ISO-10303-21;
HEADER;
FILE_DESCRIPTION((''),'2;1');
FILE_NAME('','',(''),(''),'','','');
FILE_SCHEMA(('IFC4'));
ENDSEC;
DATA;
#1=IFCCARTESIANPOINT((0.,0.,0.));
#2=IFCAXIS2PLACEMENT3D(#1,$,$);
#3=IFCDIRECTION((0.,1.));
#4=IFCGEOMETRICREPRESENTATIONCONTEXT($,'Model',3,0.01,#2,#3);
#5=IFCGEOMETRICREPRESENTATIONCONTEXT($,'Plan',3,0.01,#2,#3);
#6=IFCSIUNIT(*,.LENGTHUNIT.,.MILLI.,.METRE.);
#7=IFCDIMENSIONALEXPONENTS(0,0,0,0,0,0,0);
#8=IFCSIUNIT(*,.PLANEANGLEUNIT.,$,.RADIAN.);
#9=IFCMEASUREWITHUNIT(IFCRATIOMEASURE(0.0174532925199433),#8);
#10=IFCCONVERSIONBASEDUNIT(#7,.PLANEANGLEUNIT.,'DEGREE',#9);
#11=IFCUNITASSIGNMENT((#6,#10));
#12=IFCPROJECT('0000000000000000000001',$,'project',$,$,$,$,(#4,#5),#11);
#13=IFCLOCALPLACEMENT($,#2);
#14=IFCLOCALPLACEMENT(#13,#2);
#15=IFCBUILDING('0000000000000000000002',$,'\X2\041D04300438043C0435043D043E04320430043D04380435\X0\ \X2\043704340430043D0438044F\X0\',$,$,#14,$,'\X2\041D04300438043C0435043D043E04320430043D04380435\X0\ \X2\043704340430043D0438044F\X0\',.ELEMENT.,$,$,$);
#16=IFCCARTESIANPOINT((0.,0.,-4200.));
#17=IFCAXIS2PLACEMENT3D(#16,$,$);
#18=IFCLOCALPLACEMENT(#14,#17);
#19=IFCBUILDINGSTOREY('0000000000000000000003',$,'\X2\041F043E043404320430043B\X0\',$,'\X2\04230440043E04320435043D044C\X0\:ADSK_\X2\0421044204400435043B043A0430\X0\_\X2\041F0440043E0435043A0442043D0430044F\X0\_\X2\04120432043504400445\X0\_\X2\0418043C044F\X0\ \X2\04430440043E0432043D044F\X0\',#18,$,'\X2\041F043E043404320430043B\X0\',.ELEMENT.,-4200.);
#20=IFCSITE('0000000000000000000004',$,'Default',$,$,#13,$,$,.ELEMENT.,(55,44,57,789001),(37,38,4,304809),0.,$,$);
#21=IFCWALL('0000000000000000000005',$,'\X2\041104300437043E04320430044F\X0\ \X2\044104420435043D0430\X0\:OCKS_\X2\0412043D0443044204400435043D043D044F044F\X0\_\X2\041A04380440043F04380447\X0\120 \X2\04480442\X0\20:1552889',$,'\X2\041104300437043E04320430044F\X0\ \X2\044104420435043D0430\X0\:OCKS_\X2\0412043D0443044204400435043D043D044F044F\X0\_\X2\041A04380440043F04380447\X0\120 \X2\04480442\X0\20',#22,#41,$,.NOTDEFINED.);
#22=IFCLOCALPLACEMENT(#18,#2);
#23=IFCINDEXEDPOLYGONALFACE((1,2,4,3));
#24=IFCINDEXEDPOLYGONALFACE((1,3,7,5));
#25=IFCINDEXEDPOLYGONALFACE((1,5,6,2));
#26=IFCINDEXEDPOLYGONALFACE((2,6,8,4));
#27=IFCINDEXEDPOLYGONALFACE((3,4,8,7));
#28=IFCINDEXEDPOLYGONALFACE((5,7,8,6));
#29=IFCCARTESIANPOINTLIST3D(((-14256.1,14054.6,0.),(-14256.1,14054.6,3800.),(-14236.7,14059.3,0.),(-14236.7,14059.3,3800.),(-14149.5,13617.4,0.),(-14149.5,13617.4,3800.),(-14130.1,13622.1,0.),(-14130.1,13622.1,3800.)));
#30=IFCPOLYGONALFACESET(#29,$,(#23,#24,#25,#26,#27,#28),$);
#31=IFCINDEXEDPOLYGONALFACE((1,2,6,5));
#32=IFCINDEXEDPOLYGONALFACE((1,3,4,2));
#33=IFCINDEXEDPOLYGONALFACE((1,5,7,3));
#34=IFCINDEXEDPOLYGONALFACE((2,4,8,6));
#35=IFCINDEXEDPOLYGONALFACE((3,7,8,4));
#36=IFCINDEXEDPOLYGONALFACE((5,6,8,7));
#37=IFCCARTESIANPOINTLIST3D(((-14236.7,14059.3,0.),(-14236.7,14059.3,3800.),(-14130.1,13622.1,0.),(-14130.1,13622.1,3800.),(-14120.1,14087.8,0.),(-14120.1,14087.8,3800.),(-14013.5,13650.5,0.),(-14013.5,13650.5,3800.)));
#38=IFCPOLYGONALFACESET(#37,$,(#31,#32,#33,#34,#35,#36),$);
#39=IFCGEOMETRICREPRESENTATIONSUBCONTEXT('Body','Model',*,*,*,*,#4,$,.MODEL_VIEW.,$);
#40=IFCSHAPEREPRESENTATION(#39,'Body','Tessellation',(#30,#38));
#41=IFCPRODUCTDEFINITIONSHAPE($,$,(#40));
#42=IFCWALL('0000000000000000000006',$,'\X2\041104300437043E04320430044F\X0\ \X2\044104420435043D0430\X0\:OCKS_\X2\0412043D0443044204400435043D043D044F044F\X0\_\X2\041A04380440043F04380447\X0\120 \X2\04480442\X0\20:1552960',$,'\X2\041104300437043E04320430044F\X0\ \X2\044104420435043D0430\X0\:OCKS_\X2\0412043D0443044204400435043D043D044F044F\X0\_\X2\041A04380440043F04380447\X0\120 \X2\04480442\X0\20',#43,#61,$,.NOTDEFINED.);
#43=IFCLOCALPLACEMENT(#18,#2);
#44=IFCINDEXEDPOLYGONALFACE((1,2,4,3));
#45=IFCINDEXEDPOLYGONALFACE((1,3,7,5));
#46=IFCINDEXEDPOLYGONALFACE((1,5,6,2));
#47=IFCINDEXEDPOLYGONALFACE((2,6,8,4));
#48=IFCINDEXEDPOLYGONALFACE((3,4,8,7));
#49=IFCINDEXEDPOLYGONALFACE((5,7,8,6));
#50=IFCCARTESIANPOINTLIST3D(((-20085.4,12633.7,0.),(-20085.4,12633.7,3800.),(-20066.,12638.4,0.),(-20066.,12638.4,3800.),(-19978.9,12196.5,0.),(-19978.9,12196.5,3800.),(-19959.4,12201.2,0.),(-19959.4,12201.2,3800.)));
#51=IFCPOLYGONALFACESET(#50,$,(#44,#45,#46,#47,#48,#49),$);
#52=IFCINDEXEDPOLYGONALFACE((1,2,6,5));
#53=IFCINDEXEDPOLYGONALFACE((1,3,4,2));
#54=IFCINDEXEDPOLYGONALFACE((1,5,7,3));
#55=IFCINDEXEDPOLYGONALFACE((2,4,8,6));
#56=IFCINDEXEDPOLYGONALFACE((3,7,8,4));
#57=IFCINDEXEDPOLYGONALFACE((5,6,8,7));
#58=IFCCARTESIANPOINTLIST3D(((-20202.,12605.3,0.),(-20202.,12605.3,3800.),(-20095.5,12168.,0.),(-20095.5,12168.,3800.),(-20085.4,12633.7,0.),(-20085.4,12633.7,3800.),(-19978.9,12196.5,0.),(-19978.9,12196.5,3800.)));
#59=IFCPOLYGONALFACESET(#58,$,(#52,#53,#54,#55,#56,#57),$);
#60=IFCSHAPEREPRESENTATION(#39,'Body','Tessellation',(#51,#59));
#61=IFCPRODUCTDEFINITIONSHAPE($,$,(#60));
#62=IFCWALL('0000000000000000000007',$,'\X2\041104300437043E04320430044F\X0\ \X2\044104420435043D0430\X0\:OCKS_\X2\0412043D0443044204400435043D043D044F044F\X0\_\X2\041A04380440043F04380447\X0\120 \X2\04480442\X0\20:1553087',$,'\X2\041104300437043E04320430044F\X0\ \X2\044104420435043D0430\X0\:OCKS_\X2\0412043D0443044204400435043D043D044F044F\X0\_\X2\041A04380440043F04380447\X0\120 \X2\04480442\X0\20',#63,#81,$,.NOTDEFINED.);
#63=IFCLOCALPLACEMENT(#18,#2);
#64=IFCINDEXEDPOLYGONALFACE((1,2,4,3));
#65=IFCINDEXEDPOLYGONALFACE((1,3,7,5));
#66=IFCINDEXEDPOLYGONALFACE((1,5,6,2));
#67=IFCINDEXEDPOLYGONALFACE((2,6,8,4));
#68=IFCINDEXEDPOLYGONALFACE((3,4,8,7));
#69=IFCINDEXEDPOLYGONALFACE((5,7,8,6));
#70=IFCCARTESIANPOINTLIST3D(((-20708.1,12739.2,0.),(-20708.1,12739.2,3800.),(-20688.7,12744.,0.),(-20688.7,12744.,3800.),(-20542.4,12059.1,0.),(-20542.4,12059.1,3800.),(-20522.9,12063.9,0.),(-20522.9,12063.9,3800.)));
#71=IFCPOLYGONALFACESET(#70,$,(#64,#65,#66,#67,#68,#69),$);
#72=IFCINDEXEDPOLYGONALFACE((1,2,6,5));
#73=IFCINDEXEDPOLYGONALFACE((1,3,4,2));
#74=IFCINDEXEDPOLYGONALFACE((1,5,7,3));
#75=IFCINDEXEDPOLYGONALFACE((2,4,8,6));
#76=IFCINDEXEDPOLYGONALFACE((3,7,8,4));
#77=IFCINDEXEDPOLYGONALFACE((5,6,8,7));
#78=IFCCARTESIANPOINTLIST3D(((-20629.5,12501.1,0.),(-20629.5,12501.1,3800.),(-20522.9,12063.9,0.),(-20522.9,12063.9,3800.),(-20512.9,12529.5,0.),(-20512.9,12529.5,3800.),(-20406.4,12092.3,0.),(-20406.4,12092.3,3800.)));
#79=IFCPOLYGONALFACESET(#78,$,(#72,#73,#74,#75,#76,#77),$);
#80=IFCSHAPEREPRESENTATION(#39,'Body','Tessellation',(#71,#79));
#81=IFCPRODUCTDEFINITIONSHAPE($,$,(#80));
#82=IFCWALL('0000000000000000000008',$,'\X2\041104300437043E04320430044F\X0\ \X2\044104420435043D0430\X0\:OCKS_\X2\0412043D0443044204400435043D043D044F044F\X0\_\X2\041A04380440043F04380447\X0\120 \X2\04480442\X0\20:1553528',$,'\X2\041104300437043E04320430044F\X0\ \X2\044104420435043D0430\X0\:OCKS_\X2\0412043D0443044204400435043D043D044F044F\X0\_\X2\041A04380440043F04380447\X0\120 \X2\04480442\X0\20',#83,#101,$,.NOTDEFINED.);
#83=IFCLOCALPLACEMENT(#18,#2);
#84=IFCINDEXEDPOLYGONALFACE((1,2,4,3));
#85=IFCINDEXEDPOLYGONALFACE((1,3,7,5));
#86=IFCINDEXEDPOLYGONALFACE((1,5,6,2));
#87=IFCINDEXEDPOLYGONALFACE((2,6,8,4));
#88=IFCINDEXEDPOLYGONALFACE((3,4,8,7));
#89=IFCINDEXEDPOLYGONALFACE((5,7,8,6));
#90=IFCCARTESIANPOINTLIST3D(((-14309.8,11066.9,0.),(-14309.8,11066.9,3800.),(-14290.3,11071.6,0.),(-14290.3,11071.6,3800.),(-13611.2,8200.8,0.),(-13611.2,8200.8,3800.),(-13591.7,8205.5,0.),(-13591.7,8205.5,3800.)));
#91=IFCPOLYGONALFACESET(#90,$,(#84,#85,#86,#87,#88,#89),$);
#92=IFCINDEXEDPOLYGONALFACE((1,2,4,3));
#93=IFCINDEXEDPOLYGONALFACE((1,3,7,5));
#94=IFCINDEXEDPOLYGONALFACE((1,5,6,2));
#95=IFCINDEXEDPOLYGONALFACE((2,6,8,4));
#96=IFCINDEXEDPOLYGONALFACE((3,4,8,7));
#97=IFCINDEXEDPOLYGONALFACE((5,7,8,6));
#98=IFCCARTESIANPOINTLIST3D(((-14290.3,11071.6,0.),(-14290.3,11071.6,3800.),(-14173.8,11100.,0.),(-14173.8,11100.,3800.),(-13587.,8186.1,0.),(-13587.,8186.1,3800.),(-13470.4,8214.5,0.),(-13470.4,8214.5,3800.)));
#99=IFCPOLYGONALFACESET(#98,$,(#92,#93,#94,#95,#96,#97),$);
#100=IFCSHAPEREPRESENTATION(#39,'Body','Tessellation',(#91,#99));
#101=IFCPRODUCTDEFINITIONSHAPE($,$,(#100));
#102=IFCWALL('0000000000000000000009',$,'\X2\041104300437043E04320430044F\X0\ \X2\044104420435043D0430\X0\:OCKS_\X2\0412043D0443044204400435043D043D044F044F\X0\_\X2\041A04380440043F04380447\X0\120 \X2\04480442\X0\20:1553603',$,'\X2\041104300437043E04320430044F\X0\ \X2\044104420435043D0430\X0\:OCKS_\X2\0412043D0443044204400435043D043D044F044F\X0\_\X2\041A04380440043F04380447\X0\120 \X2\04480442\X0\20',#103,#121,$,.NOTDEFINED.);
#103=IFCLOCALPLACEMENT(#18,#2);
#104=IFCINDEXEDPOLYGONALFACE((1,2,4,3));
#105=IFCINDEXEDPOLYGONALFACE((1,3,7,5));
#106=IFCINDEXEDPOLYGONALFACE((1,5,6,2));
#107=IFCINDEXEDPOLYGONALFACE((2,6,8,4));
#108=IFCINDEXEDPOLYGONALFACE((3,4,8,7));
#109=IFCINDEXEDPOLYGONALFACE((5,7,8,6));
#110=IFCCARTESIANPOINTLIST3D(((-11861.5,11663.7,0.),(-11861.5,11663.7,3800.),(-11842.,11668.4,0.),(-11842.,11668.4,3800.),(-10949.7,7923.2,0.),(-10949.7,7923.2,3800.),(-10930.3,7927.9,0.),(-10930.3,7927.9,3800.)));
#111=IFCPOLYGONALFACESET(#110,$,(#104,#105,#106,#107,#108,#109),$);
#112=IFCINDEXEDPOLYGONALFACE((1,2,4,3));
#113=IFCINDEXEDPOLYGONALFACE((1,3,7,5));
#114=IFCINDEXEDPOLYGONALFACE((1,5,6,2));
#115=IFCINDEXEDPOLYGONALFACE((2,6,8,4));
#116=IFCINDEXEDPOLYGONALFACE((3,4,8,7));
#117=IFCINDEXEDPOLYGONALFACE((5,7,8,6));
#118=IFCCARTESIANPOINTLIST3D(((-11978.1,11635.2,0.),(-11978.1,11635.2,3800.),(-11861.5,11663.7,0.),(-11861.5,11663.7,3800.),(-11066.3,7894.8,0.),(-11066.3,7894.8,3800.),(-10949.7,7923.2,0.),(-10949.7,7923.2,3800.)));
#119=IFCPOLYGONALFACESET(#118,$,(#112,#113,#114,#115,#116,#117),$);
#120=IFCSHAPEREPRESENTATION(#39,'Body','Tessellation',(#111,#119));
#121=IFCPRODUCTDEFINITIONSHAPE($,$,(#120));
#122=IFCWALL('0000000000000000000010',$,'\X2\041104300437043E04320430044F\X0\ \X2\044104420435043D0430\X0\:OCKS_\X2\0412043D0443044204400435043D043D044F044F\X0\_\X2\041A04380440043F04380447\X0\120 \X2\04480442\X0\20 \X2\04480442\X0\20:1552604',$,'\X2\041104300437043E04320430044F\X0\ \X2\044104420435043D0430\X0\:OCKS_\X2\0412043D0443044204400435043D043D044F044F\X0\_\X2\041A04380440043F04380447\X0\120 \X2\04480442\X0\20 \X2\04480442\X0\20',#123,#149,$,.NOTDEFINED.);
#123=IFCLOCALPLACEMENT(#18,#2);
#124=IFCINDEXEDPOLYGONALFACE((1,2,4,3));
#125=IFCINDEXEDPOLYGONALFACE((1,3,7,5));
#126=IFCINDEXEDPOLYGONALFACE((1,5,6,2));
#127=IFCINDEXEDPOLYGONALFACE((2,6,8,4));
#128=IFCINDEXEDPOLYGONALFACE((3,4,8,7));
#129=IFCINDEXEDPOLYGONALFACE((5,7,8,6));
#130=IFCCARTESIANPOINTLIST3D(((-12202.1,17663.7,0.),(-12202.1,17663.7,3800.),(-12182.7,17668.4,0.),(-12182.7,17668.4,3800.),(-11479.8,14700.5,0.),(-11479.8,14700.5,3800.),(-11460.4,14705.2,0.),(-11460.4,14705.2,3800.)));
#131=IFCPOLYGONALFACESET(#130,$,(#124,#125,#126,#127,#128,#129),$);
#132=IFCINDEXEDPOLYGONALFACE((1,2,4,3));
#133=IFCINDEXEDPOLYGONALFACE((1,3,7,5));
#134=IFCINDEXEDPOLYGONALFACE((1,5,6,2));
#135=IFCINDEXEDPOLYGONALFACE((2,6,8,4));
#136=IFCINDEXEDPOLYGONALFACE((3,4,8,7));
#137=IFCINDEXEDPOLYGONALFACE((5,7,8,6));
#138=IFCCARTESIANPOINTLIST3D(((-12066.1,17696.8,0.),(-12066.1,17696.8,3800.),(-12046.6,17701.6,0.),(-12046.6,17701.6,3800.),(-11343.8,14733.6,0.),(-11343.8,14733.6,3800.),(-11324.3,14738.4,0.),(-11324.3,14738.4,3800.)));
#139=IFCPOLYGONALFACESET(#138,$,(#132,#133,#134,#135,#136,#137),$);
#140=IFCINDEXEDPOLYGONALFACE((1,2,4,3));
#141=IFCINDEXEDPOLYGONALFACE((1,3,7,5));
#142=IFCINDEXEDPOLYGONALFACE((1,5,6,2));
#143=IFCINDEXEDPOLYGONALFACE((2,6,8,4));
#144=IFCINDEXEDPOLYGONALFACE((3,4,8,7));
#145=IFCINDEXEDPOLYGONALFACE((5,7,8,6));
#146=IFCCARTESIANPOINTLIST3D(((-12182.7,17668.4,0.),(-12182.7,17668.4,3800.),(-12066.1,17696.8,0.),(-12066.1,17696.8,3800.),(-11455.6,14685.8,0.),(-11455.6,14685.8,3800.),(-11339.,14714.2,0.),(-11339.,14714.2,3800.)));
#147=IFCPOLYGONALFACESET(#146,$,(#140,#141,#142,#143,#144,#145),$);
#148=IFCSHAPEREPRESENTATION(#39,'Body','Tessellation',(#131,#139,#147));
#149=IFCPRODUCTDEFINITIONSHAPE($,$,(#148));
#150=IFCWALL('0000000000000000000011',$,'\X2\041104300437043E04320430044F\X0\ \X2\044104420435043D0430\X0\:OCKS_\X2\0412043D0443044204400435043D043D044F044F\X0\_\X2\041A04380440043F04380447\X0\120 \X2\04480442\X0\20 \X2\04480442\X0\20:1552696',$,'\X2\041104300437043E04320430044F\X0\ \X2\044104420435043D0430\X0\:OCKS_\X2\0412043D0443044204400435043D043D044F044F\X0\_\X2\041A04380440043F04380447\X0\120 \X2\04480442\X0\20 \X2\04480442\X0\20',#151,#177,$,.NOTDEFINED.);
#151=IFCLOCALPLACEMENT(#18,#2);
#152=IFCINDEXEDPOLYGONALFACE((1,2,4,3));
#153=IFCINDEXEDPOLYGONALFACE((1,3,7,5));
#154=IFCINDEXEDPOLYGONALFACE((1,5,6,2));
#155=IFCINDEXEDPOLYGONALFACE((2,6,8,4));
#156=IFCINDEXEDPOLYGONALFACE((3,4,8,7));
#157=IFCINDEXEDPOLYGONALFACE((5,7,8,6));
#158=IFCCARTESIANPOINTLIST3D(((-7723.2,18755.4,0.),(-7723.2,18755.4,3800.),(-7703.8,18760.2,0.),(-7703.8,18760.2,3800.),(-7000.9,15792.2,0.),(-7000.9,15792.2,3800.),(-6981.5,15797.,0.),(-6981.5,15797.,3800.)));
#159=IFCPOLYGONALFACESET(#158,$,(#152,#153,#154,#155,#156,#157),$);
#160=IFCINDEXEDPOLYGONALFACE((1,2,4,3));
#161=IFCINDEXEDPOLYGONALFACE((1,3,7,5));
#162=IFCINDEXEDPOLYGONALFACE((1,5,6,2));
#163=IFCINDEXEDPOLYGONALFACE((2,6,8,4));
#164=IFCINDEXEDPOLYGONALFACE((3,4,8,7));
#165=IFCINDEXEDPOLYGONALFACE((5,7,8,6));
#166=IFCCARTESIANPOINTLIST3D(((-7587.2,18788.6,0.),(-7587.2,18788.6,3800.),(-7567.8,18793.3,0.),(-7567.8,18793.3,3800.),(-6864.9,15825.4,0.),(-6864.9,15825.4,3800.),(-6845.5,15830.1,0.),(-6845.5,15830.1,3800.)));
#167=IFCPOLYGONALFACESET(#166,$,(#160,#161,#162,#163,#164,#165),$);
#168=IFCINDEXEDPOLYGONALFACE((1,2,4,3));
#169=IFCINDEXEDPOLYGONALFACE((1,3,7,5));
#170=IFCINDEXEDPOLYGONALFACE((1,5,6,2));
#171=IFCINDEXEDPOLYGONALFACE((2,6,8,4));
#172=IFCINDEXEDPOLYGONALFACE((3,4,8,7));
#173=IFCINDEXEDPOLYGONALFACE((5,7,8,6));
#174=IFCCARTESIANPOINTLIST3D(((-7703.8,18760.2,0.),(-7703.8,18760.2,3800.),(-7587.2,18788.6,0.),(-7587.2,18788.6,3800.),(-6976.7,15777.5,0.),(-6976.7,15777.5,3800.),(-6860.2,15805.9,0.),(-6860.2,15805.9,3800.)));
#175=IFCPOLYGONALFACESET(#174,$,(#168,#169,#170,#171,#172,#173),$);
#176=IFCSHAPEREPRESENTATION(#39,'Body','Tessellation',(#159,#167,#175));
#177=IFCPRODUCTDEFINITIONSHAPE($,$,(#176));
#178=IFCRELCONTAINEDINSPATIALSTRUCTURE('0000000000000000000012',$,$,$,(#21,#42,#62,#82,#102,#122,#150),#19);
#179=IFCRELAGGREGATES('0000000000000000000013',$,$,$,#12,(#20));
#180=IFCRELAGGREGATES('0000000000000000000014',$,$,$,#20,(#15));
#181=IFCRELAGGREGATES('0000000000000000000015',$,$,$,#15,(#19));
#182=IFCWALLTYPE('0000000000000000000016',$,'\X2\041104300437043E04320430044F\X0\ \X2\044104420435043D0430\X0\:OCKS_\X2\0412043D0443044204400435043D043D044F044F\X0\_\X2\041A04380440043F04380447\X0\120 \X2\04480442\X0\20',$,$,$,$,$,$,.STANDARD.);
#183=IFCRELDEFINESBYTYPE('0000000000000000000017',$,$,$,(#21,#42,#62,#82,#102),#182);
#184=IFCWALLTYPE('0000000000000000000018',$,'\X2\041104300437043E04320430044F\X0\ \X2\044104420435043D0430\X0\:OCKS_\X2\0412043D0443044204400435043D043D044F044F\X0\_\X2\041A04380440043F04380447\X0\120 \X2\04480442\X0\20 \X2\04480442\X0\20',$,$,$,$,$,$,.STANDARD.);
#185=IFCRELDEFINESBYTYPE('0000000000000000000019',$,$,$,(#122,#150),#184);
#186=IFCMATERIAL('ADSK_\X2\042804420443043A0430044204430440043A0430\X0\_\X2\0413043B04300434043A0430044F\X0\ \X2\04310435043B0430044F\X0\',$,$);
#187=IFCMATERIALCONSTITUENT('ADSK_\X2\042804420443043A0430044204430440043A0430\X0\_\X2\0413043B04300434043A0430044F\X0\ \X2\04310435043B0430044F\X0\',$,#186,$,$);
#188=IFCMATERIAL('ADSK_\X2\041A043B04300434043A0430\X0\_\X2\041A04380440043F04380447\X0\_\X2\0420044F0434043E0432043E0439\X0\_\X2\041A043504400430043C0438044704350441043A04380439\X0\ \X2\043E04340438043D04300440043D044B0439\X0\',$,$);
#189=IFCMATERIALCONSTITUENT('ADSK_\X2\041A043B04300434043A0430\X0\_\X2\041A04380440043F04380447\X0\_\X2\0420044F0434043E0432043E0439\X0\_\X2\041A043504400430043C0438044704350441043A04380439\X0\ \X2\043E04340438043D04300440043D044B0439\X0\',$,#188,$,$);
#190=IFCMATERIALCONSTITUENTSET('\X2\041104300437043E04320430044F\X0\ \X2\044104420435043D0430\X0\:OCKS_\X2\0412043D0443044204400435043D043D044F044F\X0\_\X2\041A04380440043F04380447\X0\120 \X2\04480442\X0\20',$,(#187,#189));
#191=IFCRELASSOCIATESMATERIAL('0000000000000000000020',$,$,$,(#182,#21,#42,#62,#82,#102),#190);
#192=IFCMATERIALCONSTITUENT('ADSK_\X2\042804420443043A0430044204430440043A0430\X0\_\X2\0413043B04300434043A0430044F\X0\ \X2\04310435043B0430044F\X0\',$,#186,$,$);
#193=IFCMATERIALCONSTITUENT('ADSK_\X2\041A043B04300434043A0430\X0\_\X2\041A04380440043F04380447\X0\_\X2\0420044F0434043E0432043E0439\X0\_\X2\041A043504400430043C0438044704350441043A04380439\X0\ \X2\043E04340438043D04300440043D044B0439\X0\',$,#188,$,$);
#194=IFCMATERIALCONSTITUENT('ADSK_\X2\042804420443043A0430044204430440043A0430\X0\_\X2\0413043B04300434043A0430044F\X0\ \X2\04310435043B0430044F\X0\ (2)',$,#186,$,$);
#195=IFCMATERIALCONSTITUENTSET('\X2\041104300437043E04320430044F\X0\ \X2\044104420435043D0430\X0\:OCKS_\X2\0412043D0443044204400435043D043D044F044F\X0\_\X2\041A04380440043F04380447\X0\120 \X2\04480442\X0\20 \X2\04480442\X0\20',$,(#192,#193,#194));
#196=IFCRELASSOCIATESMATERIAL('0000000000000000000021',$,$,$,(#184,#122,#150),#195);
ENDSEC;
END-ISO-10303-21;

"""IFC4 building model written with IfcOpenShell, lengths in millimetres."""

from ifc_helpers import new_model, entity, si_unit, converted_unit, direction, frame, origin, place, context, subcontext, project, spatial, indexed_curve, outline, extrude, material, constituent, constituent_set, type_object, element, save


model = new_model("IFC4")

# Units and contexts
model_context = context("Model", 3, precision=0.01, world=origin(), true_north=direction((0.0, 1.0)))
plan_context = context("Plan", 3, precision=0.01, world=origin(), true_north=direction((0.0, 1.0)))
body_context = subcontext(model_context, "Body", "Model", "MODEL_VIEW")
ifc_project = project(units=[si_unit("LENGTHUNIT", "METRE", prefix="MILLI"), converted_unit("PLANEANGLEUNIT", "DEGREE", entity("IfcRatioMeasure", 0.0174532925199433), si_unit("PLANEANGLEUNIT", "RADIAN"), dimensions=[0, 0, 0, 0, 0, 0, 0])], contexts=[model_context, plan_context])

# Site, building, storey
site_placement = place(None, frame((0.0, 0.0, 0.0)))
site = spatial("IfcSite", under=ifc_project, at=site_placement, Name="Default", CompositionType="ELEMENT", RefLatitude=(55, 44, 57, 789001), RefLongitude=(37, 38, 4, 304809), RefElevation=0.0)
building_placement = place(site_placement, origin())
building = spatial("IfcBuilding", under=site, at=building_placement, Name="Наименование здания", LongName="Наименование здания", CompositionType="ELEMENT")
storey_placement = place(building_placement, frame((0.0, 0.0, -4200.0)))
storey = spatial("IfcBuildingStorey", under=building, at=storey_placement, Name="Подвал", ObjectType="Уровень:ADSK_Стрелка_Проектная_Вверх_Имя уровня", LongName="Подвал", CompositionType="ELEMENT", Elevation=-4200.0)

# Walls
ifc_material_1 = material(Name="ADSK_Штукатурка_Гладкая белая")
ifc_constituent_1 = constituent(ifc_material_1, Name="ADSK_Штукатурка_Гладкая белая")
ifc_material_2 = material(Name="ADSK_Кладка_Кирпич_Рядовой_Керамический одинарный")
ifc_constituent_2 = constituent(ifc_material_2, Name="ADSK_Кладка_Кирпич_Рядовой_Керамический одинарный")
ifc_constituent_set_1 = constituent_set(constituents=[ifc_constituent_1, ifc_constituent_2], Name="Базовая стена:OCKS_Внутренняя_Кирпич120 шт20")
wall_type_1 = type_object("IfcWallType", Name="Базовая стена:OCKS_Внутренняя_Кирпич120 шт20", PredefinedType="STANDARD", material=ifc_constituent_set_1)
wall_1_placement = place(storey_placement, frame((-14081.5, 13634.0, 0.0), z_axis=(0.0, 0.0, 1.0), x_axis=(-0.236821, 0.971553, 0.0)))
element("IfcWall", 1, at=wall_1_placement, inside=storey, type_object=wall_type_1, material=ifc_constituent_set_1, Name="Базовая стена:OCKS_Внутренняя_Кирпич120 шт20:1552889", ObjectType="Базовая стена:OCKS_Внутренняя_Кирпич120 шт20", PredefinedType="NOTDEFINED", context=body_context, shape_type="SweptSolid", body=[
    extrude(outline(indexed_curve([(-10.0, -225.0), (10.0, -225.0), (10.0, 225.0), (-10.0, 225.0), (-10.0, -225.0)], self_intersect=False)), frame((225.0, 60.0, 0.0), z_axis=(0.0, 0.0, 1.0), x_axis=(0.0, -1.0, 0.0)), (0.0, 0.0, 1.0), 3800.0),
    extrude(outline(indexed_curve([(-60.0, -225.0), (60.0, -225.0), (60.0, 225.0), (-60.0, 225.0), (-60.0, -225.0)], self_intersect=False)), frame((225.0, -10.0, 0.0), z_axis=(0.0, 0.0, 1.0), x_axis=(0.0, 1.0, 0.0)), (0.0, 0.0, 1.0), 3800.0),
])
wall_2_placement = place(storey_placement, frame((-20027.4, 12184.6, 0.0), z_axis=(0.0, 0.0, 1.0), x_axis=(-0.23682, 0.971553, 0.0)))
element("IfcWall", 2, at=wall_2_placement, inside=storey, type_object=wall_type_1, material=ifc_constituent_set_1, Name="Базовая стена:OCKS_Внутренняя_Кирпич120 шт20:1552960", ObjectType="Базовая стена:OCKS_Внутренняя_Кирпич120 шт20", PredefinedType="NOTDEFINED", context=body_context, shape_type="SweptSolid", body=[
    extrude(outline(indexed_curve([(-10.0, -225.0), (10.0, -225.0), (10.0, 225.0), (-10.0, 225.0), (-10.0, -225.0)], self_intersect=False)), frame((225.0, -60.0, 0.0), z_axis=(0.0, 0.0, 1.0), x_axis=(0.0, 1.0, 0.0)), (0.0, 0.0, 1.0), 3800.0),
    extrude(outline(indexed_curve([(-60.0, -225.0), (60.0, -225.0), (60.0, 225.0), (-60.0, 225.0), (-60.0, -225.0)], self_intersect=False)), frame((225.0, 10.0, 0.0), z_axis=(0.0, 0.0, 1.0), x_axis=(0.0, -1.0, 0.0)), (0.0, 0.0, 1.0), 3800.0),
])
wall_3_placement = place(storey_placement, frame((-20580.9, 12512.9, 0.0), z_axis=(0.0, 0.0, 1.0), x_axis=(0.236822, -0.971553, 0.0)))
element("IfcWall", 3, at=wall_3_placement, inside=storey, type_object=wall_type_1, material=ifc_constituent_set_1, Name="Базовая стена:OCKS_Внутренняя_Кирпич120 шт20:1553087", ObjectType="Базовая стена:OCKS_Внутренняя_Кирпич120 шт20", PredefinedType="NOTDEFINED", context=body_context, shape_type="SweptSolid", body=[
    extrude(outline(indexed_curve([(-10.0, -350.0), (10.0, -350.0), (10.0, 350.0), (-10.0, 350.0), (-10.0, -350.0)], self_intersect=False)), frame((100.0, -60.0, 0.0), z_axis=(0.0, 0.0, 1.0), x_axis=(0.0, 1.0, 0.0)), (0.0, 0.0, 1.0), 3800.0),
    extrude(outline(indexed_curve([(-60.0, -225.0), (60.0, -225.0), (60.0, 225.0), (-60.0, 225.0), (-60.0, -225.0)], self_intersect=False)), frame((225.0, 10.0, 0.0), z_axis=(0.0, 0.0, 1.0), x_axis=(-0.000002, -1.0, 0.0)), (0.0, 0.0, 1.0), 3800.0),
])
wall_4_placement = place(storey_placement, frame((-13543.2, 8217.4, 0.0), z_axis=(0.0, 0.0, 1.0), x_axis=(-0.236815, 0.971555, 0.0)))
element("IfcWall", 4, at=wall_4_placement, inside=storey, type_object=wall_type_1, material=ifc_constituent_set_1, Name="Базовая стена:OCKS_Внутренняя_Кирпич120 шт20:1553528", ObjectType="Базовая стена:OCKS_Внутренняя_Кирпич120 шт20", PredefinedType="NOTDEFINED", context=body_context, shape_type="SweptSolid", body=[
    extrude(outline(indexed_curve([(-10.0, -1475.0), (10.0, -1475.0), (10.0, 1475.0), (-10.0, 1475.0), (-10.0, -1475.0)], self_intersect=False)), frame((1475.0, 60.0, 0.0), z_axis=(0.0, 0.0, 1.0), x_axis=(0.000006, -1.0, 0.0)), (0.0, 0.0, 1.0), 3800.0),
    extrude(outline(indexed_curve([(-60.0, -1485.0), (60.0, -1485.0), (60.0, 1485.0), (-60.0, 1485.0), (-60.0, -1485.0)], self_intersect=False)), frame((1465.0, -10.0, 0.0), z_axis=(0.0, 0.0, 1.0), x_axis=(-0.000006, 1.0, 0.0)), (0.0, 0.0, 1.0), 3800.0),
])
wall_5_placement = place(storey_placement, frame((-11910.1, 11651.8, 0.0), z_axis=(0.0, 0.0, 1.0), x_axis=(0.236821, -0.971553, 0.0)))
element("IfcWall", 5, at=wall_5_placement, inside=storey, type_object=wall_type_1, material=ifc_constituent_set_1, Name="Базовая стена:OCKS_Внутренняя_Кирпич120 шт20:1553603", ObjectType="Базовая стена:OCKS_Внутренняя_Кирпич120 шт20", PredefinedType="NOTDEFINED", context=body_context, shape_type="SweptSolid", body=[
    extrude(outline(indexed_curve([(-10.0, -1925.0), (10.0, -1925.0), (10.0, 1925.0), (-10.0, 1925.0), (-10.0, -1925.0)], self_intersect=False)), frame((1925.0, 60.0, 0.0), z_axis=(0.0, 0.0, 1.0), x_axis=(0.0, -1.0, 0.0)), (0.0, 0.0, 1.0), 3800.0),
    extrude(outline(indexed_curve([(-60.0, -1925.0), (60.0, -1925.0), (60.0, 1925.0), (-60.0, 1925.0), (-60.0, -1925.0)], self_intersect=False)), frame((1925.0, -10.0, 0.0), z_axis=(0.0, 0.0, 1.0), x_axis=(0.0, 1.0, 0.0)), (0.0, 0.0, 1.0), 3800.0),
])
ifc_constituent_3 = constituent(ifc_material_1, Name="ADSK_Штукатурка_Гладкая белая")
ifc_constituent_4 = constituent(ifc_material_2, Name="ADSK_Кладка_Кирпич_Рядовой_Керамический одинарный")
ifc_constituent_5 = constituent(ifc_material_1, Name="ADSK_Штукатурка_Гладкая белая (2)")
ifc_constituent_set_2 = constituent_set(constituents=[ifc_constituent_3, ifc_constituent_4, ifc_constituent_5], Name="Базовая стена:OCKS_Внутренняя_Кирпич120 шт20 шт20")
wall_type_2 = type_object("IfcWallType", Name="Базовая стена:OCKS_Внутренняя_Кирпич120 шт20 шт20", PredefinedType="STANDARD", material=ifc_constituent_set_2)
wall_6_placement = place(storey_placement, frame((-11402.1, 14719.4, 0.0), z_axis=(0.0, 0.0, 1.0), x_axis=(-0.236821, 0.971553, 0.0)))
element("IfcWall", 6, at=wall_6_placement, inside=storey, type_object=wall_type_2, material=ifc_constituent_set_2, Name="Базовая стена:OCKS_Внутренняя_Кирпич120 шт20 шт20:1552604", ObjectType="Базовая стена:OCKS_Внутренняя_Кирпич120 шт20 шт20", PredefinedType="NOTDEFINED", context=body_context, shape_type="SweptSolid", body=[
    extrude(outline(indexed_curve([(-10.0, -1525.0), (10.0, -1525.0), (10.0, 1525.0), (-10.0, 1525.0), (-10.0, -1525.0)], self_intersect=False)), frame((1525.0, 70.0, 0.0), z_axis=(0.0, 0.0, 1.0), x_axis=(0.0, -1.0, 0.0)), (0.0, 0.0, 1.0), 3800.0),
    extrude(outline(indexed_curve([(-10.0, -1525.0), (10.0, -1525.0), (10.0, 1525.0), (-10.0, 1525.0), (-10.0, -1525.0)], self_intersect=False)), frame((1525.0, -70.0, 0.0), z_axis=(0.0, 0.0, 1.0), x_axis=(-0.000002, 1.0, 0.0)), (0.0, 0.0, 1.0), 3800.0),
    extrude(outline(indexed_curve([(-1535.0, -60.0), (1535.0, -60.0), (1535.0, 60.0), (-1535.0, 60.0), (-1535.0, -60.0)], self_intersect=False)), frame((1515.0, 0.0, 0.0)), (0.0, 0.0, 1.0), 3800.0),
])
wall_7_placement = place(storey_placement, frame((-6923.2, 15811.2, 0.0), z_axis=(0.0, 0.0, 1.0), x_axis=(-0.236821, 0.971553, 0.0)))
element("IfcWall", 7, at=wall_7_placement, inside=storey, type_object=wall_type_2, material=ifc_constituent_set_2, Name="Базовая стена:OCKS_Внутренняя_Кирпич120 шт20 шт20:1552696", ObjectType="Базовая стена:OCKS_Внутренняя_Кирпич120 шт20 шт20", PredefinedType="NOTDEFINED", context=body_context, shape_type="SweptSolid", body=[
    extrude(outline(indexed_curve([(-10.0, -1525.0), (10.0, -1525.0), (10.0, 1525.0), (-10.0, 1525.0), (-10.0, -1525.0)], self_intersect=False)), frame((1525.0, 70.0, 0.0), z_axis=(0.0, 0.0, 1.0), x_axis=(0.0, -1.0, 0.0)), (0.0, 0.0, 1.0), 3800.0),
    extrude(outline(indexed_curve([(-10.0, -1525.0), (10.0, -1525.0), (10.0, 1525.0), (-10.0, 1525.0), (-10.0, -1525.0)], self_intersect=False)), frame((1525.0, -70.0, 0.0), z_axis=(0.0, 0.0, 1.0), x_axis=(-0.000002, 1.0, 0.0)), (0.0, 0.0, 1.0), 3800.0),
    extrude(outline(indexed_curve([(-1535.0, -60.0), (1535.0, -60.0), (1535.0, 60.0), (-1535.0, 60.0), (-1535.0, -60.0)], self_intersect=False)), frame((1515.0, 0.0, 0.0)), (0.0, 0.0, 1.0), 3800.0),
])

save(model, "model.ifc")
